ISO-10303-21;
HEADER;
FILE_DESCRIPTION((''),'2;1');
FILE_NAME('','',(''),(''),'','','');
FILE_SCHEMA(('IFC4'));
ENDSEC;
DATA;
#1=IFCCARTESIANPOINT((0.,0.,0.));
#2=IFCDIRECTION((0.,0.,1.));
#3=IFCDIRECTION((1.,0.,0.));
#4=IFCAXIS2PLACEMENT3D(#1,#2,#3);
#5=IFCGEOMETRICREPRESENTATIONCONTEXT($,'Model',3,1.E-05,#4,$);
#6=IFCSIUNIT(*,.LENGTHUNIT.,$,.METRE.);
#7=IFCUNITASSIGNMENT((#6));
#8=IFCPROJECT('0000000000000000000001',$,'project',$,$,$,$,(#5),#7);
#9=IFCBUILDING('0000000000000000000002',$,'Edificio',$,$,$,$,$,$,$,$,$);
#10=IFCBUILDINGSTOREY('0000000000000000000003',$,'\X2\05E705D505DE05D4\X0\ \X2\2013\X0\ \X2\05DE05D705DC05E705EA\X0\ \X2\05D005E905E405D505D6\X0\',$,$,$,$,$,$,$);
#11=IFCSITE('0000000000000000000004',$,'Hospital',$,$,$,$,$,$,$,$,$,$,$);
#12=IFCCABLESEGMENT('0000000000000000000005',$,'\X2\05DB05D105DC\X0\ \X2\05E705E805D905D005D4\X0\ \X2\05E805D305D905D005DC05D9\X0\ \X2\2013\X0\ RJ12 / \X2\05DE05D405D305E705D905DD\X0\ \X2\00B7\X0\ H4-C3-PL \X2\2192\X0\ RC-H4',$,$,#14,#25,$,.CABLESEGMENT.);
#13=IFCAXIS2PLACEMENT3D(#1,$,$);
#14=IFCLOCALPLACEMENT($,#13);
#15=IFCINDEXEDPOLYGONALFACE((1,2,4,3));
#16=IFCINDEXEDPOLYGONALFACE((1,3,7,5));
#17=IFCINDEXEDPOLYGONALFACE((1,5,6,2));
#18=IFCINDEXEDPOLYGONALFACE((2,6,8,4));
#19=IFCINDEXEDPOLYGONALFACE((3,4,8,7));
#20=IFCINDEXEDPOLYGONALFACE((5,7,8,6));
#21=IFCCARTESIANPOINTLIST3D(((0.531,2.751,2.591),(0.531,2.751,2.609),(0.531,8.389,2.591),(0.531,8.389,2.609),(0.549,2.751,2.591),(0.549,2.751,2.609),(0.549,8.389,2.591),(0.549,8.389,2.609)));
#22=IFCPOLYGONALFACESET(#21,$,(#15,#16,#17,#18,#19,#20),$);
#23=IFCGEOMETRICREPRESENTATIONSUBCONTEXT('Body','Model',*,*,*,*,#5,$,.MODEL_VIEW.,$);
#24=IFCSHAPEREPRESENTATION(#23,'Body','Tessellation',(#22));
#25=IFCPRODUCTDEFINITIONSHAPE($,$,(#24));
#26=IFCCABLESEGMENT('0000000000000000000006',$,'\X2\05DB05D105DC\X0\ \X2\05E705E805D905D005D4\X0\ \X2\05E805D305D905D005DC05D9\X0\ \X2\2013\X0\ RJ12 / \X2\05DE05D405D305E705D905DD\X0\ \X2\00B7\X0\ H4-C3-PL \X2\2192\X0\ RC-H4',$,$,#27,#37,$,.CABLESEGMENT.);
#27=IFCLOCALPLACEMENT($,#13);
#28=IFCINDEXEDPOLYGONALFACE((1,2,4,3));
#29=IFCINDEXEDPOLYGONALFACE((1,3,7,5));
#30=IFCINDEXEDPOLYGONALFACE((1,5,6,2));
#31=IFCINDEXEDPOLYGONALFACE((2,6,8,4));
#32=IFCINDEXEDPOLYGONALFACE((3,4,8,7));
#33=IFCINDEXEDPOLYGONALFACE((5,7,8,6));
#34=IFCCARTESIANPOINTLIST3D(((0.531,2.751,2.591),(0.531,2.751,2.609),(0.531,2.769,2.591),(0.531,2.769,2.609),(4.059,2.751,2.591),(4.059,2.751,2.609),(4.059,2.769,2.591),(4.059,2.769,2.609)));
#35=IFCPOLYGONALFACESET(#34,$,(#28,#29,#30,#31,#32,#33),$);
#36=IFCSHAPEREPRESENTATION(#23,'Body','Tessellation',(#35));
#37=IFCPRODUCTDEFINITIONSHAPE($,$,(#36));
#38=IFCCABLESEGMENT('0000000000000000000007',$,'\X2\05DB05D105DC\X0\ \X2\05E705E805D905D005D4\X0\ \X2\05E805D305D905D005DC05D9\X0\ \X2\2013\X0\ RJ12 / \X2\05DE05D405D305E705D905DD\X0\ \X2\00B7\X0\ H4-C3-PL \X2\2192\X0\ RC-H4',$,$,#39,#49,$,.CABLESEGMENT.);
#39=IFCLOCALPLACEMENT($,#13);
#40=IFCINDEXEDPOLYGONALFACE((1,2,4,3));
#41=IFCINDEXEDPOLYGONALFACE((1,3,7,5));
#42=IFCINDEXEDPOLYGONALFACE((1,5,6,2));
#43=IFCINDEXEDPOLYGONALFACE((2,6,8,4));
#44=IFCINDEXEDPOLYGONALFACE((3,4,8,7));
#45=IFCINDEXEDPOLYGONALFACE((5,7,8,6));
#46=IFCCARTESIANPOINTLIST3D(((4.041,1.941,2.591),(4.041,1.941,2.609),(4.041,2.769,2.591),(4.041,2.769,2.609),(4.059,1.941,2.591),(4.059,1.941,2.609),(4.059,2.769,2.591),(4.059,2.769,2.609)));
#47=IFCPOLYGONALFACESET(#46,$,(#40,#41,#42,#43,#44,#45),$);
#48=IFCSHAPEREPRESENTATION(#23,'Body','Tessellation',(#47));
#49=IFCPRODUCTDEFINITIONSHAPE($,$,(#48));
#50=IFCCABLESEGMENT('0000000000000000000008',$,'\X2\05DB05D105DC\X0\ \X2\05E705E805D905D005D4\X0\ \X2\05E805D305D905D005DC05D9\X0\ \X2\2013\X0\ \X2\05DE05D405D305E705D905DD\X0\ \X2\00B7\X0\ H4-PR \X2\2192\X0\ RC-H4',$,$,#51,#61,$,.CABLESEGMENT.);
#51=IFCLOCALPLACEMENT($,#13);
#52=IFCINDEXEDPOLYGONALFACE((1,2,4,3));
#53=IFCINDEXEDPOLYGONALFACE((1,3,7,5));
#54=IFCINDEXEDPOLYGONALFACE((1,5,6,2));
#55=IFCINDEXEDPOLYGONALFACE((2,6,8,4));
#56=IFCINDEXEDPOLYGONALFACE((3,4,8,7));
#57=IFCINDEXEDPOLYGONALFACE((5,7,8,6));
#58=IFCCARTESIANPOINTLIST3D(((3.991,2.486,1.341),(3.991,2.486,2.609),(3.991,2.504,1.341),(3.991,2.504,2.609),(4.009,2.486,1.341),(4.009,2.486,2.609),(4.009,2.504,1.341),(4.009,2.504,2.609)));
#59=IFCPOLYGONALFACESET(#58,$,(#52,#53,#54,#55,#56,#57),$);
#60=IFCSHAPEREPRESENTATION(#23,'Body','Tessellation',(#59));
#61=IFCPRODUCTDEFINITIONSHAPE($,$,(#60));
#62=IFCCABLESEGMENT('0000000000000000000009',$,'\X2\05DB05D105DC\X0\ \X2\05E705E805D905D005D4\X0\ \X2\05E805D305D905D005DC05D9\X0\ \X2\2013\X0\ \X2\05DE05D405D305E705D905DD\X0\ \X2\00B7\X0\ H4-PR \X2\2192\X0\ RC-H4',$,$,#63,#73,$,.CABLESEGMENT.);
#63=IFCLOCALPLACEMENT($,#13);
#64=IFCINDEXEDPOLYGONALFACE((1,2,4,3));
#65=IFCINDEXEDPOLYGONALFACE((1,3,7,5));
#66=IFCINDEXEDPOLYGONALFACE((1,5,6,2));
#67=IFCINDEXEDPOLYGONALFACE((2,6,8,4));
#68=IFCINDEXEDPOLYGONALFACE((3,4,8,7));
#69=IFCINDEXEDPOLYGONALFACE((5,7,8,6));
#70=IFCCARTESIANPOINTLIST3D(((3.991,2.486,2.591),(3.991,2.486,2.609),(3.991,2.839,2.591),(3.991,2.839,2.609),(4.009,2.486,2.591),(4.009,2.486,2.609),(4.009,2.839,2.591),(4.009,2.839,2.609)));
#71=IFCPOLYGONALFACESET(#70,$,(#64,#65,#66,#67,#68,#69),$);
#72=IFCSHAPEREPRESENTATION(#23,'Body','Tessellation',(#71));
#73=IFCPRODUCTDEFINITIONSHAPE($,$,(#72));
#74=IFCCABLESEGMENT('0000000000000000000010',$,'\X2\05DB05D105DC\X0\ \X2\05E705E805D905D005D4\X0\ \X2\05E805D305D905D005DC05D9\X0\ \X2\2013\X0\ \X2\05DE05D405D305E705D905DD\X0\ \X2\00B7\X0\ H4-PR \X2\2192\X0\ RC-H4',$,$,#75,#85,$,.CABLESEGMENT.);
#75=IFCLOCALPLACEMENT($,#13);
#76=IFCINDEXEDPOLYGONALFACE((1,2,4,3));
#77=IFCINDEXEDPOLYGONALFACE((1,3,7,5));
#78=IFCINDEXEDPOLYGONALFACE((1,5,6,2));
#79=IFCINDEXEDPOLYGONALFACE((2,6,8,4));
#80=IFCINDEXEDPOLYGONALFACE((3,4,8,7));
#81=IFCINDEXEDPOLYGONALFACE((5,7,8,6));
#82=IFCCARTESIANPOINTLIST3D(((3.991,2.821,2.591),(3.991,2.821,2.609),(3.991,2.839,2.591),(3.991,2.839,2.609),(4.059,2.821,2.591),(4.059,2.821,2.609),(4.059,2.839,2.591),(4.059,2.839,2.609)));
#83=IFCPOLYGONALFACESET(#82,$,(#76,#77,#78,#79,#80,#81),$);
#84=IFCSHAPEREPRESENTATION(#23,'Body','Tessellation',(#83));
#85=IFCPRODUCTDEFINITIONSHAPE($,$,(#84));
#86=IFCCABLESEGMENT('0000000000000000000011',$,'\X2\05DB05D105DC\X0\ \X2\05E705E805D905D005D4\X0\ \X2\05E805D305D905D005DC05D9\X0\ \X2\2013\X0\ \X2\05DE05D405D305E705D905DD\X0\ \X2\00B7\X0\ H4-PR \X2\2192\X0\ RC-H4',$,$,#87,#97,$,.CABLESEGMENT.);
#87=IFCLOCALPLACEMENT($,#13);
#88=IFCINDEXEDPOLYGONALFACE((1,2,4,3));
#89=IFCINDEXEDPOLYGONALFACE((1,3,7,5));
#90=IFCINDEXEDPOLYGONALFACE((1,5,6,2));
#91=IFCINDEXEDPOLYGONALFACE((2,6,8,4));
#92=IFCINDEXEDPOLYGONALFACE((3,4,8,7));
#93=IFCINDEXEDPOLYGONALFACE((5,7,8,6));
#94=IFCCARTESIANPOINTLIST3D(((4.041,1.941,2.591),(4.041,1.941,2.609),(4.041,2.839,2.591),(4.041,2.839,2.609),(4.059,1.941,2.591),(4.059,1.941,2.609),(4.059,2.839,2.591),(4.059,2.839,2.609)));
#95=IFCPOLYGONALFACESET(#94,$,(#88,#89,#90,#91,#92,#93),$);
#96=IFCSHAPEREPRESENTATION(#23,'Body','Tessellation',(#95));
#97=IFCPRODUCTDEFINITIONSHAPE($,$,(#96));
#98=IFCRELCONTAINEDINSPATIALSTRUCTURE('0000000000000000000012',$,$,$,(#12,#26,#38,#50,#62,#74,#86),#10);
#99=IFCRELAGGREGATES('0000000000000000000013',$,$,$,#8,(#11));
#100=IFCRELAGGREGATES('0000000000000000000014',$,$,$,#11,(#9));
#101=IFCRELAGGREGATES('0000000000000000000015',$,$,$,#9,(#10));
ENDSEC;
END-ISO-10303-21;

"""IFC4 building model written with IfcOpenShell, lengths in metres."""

from ifc_helpers import new_model, si_unit, frame, origin_with_axes, context, subcontext, project, spatial, line, indexed_curve, outline, extrude, element, save


model = new_model("IFC4")

# Units and contexts
model_context = context("Model", 3, precision=1e-05, world=origin_with_axes())
body_context = subcontext(model_context, "Body", "Model", "MODEL_VIEW")
ifc_project = project(units=[si_unit("LENGTHUNIT", "METRE")], contexts=[model_context])

# Site, building, storey
site = spatial("IfcSite", under=ifc_project, Name="Hospital")
building = spatial("IfcBuilding", under=site, Name="Edificio")
storey = spatial("IfcBuildingStorey", under=building, Name="קומה – מחלקת אשפוז")

# Cable segments
element("IfcCableSegment", 1, inside=storey, Name="כבל קריאה רדיאלי – RJ12 / מהדקים · H4-C3-PL → RC-H4", PredefinedType="CABLESEGMENT", context=body_context, shape_type="SweptSolid", body=[
    extrude(outline(indexed_curve([(0.0, 0.0), (0.018, 0.0), (0.018, 5.638), (0.0, 5.638)], segments=[line(1, 2, 3, 4, 1)])), frame((0.531, 2.751, 2.591), z_axis=(0.0, 0.0, 1.0), x_axis=(1.0, 0.0, 0.0)), (0.0, 0.0, 1.0), 0.018),
])
element("IfcCableSegment", 2, inside=storey, Name="כבל קריאה רדיאלי – RJ12 / מהדקים · H4-C3-PL → RC-H4", PredefinedType="CABLESEGMENT", context=body_context, shape_type="SweptSolid", body=[
    extrude(outline(indexed_curve([(0.0, 0.0), (3.528, 0.0), (3.528, 0.018), (0.0, 0.018)], segments=[line(1, 2, 3, 4, 1)])), frame((0.531, 2.751, 2.591), z_axis=(0.0, 0.0, 1.0), x_axis=(1.0, 0.0, 0.0)), (0.0, 0.0, 1.0), 0.018),
])
element("IfcCableSegment", 3, inside=storey, Name="כבל קריאה רדיאלי – RJ12 / מהדקים · H4-C3-PL → RC-H4", PredefinedType="CABLESEGMENT", context=body_context, shape_type="SweptSolid", body=[
    extrude(outline(indexed_curve([(0.0, 0.0), (0.018, 0.0), (0.018, 0.828), (0.0, 0.828)], segments=[line(1, 2, 3, 4, 1)])), frame((4.041, 1.941, 2.591), z_axis=(0.0, 0.0, 1.0), x_axis=(1.0, 0.0, 0.0)), (0.0, 0.0, 1.0), 0.018),
])
element("IfcCableSegment", 4, inside=storey, Name="כבל קריאה רדיאלי – מהדקים · H4-PR → RC-H4", PredefinedType="CABLESEGMENT", context=body_context, shape_type="SweptSolid", body=[
    extrude(outline(indexed_curve([(0.0, 0.0), (0.018, 0.0), (0.018, 0.018), (0.0, 0.018)], segments=[line(1, 2, 3, 4, 1)])), frame((3.991, 2.486, 1.341), z_axis=(0.0, 0.0, 1.0), x_axis=(1.0, 0.0, 0.0)), (0.0, 0.0, 1.0), 1.268),
])
element("IfcCableSegment", 5, inside=storey, Name="כבל קריאה רדיאלי – מהדקים · H4-PR → RC-H4", PredefinedType="CABLESEGMENT", context=body_context, shape_type="SweptSolid", body=[
    extrude(outline(indexed_curve([(0.0, 0.0), (0.018, 0.0), (0.018, 0.353), (0.0, 0.353)], segments=[line(1, 2, 3, 4, 1)])), frame((3.991, 2.486, 2.591), z_axis=(0.0, 0.0, 1.0), x_axis=(1.0, 0.0, 0.0)), (0.0, 0.0, 1.0), 0.018),
])
element("IfcCableSegment", 6, inside=storey, Name="כבל קריאה רדיאלי – מהדקים · H4-PR → RC-H4", PredefinedType="CABLESEGMENT", context=body_context, shape_type="SweptSolid", body=[
    extrude(outline(indexed_curve([(0.0, 0.0), (0.068, 0.0), (0.068, 0.018), (0.0, 0.018)], segments=[line(1, 2, 3, 4, 1)])), frame((3.991, 2.821, 2.591), z_axis=(0.0, 0.0, 1.0), x_axis=(1.0, 0.0, 0.0)), (0.0, 0.0, 1.0), 0.018),
])
element("IfcCableSegment", 7, inside=storey, Name="כבל קריאה רדיאלי – מהדקים · H4-PR → RC-H4", PredefinedType="CABLESEGMENT", context=body_context, shape_type="SweptSolid", body=[
    extrude(outline(indexed_curve([(0.0, 0.0), (0.018, 0.0), (0.018, 0.898), (0.0, 0.898)], segments=[line(1, 2, 3, 4, 1)])), frame((4.041, 1.941, 2.591), z_axis=(0.0, 0.0, 1.0), x_axis=(1.0, 0.0, 0.0)), (0.0, 0.0, 1.0), 0.018),
])

save(model, "model.ifc")
